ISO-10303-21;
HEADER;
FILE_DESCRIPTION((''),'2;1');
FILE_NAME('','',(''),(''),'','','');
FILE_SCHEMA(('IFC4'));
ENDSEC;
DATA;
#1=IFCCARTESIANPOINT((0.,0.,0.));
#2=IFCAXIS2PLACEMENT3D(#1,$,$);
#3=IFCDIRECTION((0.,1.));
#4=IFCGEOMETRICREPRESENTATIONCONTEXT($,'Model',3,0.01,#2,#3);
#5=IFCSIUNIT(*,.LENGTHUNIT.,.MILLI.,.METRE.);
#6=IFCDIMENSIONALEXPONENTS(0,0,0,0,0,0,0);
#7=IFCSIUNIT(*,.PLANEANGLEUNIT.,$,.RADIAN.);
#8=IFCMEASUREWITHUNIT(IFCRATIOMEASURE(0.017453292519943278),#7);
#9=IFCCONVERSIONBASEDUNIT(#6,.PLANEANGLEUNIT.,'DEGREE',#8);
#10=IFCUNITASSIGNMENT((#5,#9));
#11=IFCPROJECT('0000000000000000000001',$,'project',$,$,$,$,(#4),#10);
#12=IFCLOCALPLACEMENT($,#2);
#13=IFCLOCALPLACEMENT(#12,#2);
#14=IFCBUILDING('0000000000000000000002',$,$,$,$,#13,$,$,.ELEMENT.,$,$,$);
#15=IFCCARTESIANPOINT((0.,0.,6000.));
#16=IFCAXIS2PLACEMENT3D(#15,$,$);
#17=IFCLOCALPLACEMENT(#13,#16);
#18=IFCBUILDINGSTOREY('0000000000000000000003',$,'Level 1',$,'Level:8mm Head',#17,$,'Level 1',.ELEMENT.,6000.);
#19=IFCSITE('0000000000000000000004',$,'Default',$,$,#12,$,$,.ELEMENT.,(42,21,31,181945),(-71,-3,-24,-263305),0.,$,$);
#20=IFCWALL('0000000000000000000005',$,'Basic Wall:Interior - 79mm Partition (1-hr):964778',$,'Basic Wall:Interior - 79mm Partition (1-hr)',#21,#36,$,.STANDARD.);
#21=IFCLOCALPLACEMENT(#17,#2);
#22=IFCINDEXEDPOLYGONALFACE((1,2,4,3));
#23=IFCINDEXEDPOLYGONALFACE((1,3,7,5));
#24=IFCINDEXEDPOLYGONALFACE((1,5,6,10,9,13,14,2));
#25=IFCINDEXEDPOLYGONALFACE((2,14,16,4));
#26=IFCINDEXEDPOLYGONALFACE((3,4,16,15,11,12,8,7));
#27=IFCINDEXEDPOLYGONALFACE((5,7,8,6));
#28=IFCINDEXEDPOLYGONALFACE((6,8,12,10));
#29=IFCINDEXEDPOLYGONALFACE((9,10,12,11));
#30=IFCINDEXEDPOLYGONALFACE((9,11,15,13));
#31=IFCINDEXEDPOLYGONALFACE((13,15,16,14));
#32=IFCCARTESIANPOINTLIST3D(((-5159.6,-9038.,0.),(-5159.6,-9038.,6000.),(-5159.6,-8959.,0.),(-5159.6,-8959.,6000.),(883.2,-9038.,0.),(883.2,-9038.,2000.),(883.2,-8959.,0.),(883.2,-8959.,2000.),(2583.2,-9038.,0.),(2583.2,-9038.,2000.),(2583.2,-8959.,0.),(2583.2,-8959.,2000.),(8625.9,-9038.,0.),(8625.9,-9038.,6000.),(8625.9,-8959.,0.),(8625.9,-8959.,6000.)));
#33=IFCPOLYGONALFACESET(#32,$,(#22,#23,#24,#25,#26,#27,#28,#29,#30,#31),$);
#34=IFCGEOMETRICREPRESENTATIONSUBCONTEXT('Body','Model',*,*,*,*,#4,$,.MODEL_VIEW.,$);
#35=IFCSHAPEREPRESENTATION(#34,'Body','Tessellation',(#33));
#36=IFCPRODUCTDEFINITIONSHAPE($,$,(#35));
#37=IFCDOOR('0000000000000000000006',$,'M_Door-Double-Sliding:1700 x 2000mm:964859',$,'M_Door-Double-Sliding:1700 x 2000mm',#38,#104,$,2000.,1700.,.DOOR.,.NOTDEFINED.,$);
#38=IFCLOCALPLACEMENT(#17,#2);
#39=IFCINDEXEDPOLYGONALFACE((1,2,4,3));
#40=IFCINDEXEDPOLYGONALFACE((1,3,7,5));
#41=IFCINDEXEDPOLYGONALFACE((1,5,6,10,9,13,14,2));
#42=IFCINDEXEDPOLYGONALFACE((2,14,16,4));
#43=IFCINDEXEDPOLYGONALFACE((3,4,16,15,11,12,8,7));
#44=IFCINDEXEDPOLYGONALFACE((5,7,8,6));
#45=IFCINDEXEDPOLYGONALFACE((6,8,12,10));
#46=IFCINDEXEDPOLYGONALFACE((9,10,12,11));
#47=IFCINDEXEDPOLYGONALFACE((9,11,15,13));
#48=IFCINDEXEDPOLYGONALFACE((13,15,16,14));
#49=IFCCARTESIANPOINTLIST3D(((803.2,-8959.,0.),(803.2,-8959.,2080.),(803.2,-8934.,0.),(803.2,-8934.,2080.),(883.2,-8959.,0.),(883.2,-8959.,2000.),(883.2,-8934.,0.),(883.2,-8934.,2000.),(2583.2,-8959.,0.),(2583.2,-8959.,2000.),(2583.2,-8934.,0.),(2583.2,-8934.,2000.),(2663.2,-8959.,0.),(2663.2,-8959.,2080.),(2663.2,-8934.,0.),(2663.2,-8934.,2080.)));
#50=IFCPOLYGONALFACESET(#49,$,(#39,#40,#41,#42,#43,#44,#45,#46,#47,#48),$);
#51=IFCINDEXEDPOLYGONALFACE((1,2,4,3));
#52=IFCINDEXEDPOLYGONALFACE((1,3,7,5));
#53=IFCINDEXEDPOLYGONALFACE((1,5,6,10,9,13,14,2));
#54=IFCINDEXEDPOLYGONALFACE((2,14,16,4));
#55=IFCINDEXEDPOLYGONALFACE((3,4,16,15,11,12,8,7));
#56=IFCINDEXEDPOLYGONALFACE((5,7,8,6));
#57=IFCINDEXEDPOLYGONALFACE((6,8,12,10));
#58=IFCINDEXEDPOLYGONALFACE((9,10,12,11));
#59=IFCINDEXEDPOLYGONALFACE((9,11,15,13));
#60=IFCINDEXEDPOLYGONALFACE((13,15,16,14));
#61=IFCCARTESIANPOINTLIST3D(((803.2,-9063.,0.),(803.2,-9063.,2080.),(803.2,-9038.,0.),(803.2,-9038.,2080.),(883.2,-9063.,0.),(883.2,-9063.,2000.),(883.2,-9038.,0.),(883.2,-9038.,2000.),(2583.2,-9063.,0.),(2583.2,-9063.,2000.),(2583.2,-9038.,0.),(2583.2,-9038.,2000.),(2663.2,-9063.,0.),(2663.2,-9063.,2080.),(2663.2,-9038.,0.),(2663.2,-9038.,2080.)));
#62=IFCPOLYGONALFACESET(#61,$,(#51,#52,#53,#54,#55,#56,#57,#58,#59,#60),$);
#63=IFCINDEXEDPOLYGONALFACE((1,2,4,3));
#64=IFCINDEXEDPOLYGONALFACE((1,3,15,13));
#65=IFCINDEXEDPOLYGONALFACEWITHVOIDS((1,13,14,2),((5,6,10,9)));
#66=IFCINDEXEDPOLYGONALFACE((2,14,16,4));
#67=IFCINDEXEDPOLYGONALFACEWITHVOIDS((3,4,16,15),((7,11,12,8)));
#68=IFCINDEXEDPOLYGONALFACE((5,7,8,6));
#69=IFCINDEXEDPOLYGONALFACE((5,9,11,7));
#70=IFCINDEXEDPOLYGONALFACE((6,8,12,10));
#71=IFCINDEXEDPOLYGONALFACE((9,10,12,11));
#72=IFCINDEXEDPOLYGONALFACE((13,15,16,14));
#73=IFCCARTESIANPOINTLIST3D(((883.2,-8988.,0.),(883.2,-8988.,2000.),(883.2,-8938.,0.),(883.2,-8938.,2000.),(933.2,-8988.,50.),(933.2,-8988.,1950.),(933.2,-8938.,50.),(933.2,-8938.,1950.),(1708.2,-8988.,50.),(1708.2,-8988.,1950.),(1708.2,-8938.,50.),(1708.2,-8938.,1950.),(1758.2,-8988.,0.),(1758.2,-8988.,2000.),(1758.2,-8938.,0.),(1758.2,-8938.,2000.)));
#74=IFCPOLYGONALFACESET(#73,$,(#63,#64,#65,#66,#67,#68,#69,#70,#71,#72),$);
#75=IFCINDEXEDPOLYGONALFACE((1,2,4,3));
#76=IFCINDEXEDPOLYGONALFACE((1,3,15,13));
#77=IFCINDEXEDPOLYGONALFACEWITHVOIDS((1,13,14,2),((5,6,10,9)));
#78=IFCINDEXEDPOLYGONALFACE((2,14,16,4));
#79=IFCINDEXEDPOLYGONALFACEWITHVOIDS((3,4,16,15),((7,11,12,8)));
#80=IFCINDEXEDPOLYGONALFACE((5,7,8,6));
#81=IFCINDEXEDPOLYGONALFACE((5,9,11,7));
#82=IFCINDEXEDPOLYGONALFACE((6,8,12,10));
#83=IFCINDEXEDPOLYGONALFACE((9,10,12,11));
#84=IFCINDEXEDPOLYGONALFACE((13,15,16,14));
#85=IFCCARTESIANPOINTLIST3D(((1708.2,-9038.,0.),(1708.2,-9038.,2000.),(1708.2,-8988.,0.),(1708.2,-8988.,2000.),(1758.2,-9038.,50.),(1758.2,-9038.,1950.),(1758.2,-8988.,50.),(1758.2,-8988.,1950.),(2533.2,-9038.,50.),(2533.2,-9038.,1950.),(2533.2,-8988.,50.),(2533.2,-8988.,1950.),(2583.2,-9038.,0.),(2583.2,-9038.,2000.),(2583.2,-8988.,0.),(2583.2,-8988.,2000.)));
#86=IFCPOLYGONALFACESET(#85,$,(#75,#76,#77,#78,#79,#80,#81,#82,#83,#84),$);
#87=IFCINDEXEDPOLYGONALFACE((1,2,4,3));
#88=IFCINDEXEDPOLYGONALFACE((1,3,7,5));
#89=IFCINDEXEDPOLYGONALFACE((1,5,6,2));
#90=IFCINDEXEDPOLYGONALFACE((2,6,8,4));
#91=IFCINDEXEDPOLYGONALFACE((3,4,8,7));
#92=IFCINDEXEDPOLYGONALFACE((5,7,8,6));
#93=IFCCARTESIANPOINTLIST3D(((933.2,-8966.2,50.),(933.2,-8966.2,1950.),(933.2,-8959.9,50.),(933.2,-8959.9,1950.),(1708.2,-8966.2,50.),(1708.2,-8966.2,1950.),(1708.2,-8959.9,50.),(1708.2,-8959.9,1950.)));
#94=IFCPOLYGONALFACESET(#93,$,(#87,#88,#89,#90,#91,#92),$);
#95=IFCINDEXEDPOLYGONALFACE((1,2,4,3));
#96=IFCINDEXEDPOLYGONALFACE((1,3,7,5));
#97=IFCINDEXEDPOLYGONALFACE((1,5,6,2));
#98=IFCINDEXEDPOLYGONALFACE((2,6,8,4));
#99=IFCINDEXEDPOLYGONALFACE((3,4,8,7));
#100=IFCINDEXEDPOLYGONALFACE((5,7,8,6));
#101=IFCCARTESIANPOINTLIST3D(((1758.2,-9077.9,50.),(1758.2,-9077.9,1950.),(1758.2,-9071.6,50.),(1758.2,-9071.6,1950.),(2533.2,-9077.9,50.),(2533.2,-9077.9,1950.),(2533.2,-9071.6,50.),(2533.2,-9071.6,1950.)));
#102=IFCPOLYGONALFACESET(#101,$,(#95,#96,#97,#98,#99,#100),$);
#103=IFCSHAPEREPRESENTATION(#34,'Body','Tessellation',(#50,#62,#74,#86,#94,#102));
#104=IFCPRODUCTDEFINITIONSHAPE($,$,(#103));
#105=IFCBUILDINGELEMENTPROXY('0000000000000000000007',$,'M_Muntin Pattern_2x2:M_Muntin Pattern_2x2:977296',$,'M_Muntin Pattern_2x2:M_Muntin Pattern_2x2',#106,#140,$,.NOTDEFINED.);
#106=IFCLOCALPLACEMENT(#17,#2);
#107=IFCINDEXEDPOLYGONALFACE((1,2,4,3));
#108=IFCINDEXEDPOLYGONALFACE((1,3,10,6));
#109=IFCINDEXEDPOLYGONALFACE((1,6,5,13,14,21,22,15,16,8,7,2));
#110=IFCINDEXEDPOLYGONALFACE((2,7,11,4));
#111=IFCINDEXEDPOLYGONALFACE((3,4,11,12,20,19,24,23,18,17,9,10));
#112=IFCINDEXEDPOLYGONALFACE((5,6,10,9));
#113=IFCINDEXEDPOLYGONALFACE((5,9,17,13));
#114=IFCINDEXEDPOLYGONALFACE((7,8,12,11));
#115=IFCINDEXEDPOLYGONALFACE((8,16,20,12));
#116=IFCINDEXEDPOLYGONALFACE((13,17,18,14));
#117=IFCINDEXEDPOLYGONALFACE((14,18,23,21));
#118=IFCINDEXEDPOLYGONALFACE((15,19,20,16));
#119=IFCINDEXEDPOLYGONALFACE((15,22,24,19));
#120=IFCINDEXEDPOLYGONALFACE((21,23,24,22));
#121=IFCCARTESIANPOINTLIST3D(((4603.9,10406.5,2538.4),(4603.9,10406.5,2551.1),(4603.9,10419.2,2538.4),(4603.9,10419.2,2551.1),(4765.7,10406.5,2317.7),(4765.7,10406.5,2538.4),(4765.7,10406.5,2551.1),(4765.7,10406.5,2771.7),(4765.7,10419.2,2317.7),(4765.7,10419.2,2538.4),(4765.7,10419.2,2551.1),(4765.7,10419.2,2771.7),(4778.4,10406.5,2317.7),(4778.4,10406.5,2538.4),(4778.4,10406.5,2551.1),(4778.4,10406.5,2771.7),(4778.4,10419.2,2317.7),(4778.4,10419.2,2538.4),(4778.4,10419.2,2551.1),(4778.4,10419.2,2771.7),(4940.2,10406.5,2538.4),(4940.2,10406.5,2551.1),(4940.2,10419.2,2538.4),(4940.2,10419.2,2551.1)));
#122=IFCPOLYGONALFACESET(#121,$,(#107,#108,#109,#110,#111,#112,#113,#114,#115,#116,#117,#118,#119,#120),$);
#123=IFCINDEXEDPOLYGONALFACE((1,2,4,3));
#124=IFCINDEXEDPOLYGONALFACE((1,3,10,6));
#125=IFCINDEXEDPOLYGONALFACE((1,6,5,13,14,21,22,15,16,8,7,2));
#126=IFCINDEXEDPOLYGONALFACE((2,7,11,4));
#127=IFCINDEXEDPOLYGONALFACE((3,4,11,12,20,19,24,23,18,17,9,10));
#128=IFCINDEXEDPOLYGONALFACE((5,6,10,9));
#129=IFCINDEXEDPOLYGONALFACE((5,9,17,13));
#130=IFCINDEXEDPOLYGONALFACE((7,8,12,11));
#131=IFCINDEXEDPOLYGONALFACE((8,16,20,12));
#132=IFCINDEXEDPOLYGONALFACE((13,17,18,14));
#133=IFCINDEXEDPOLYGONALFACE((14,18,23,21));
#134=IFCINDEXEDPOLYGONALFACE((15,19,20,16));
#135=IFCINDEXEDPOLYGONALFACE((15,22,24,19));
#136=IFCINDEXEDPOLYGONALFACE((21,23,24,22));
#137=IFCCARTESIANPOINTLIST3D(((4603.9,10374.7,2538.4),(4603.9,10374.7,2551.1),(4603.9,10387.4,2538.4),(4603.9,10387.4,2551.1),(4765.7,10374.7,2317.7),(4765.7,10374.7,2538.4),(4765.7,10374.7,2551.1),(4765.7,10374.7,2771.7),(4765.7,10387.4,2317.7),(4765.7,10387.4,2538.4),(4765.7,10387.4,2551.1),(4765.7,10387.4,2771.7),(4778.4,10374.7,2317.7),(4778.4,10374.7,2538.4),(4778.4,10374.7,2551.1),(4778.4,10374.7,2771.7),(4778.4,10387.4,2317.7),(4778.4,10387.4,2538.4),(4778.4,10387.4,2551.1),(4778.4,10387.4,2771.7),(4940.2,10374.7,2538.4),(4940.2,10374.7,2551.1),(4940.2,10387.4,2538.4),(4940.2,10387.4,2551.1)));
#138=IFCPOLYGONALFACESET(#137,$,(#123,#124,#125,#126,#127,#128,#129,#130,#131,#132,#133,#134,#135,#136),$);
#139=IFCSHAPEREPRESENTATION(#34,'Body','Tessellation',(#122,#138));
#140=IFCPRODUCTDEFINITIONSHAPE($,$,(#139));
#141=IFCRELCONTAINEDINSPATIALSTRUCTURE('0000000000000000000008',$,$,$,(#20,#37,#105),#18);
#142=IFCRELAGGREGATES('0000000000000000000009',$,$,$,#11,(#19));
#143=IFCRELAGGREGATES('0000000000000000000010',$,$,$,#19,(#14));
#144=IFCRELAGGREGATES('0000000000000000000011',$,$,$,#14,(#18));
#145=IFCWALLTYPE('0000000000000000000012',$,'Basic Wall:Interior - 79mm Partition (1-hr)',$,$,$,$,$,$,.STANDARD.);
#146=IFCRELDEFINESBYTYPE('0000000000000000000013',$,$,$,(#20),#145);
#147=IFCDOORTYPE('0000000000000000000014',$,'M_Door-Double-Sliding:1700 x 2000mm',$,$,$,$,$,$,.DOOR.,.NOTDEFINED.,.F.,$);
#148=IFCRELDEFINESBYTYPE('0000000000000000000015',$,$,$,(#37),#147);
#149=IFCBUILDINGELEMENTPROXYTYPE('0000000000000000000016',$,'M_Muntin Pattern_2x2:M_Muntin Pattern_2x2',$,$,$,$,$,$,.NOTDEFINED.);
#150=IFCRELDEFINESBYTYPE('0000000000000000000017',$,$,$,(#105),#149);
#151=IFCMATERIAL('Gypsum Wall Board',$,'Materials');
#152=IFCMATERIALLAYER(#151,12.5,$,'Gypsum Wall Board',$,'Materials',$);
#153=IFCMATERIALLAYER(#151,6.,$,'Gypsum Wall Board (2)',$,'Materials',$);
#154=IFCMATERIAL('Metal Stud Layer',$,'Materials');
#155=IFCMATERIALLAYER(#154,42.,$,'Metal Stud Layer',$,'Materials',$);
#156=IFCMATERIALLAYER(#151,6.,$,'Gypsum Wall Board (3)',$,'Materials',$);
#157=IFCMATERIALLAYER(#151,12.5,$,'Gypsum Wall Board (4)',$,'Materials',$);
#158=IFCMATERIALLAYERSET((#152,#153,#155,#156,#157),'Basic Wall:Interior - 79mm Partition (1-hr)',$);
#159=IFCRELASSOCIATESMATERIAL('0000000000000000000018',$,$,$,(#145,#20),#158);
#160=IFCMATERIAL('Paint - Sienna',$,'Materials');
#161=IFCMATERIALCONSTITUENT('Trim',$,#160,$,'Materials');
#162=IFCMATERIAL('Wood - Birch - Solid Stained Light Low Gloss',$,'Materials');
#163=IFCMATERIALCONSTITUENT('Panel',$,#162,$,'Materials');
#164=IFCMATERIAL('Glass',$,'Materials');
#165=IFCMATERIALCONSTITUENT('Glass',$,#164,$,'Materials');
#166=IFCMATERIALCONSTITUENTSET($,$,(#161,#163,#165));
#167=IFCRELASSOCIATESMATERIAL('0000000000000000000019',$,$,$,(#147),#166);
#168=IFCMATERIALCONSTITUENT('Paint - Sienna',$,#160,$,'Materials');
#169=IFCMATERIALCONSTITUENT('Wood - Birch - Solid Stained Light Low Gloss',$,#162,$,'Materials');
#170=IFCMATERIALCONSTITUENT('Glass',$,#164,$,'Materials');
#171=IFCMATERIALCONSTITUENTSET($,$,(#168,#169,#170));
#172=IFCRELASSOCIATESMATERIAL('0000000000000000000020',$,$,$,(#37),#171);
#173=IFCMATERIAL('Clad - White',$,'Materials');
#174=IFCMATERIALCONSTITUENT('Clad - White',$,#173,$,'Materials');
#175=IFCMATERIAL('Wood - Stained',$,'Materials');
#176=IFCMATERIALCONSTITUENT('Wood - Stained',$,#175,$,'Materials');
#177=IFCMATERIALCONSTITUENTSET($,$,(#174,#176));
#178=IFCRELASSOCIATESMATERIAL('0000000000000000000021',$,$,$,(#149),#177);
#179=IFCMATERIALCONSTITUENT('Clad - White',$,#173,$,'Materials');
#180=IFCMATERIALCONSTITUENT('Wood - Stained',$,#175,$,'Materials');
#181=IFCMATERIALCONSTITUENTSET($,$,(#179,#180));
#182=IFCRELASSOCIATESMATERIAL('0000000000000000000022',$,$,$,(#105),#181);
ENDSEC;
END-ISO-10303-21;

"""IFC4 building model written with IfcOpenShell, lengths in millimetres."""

from ifc_helpers import new_model, entity, si_unit, converted_unit, direction, frame, frame_2d, origin, origin_2d_with_axis, place, context, subcontext, project, spatial, polyline, rectangle, outline, extrude, source, transform, mapped, material, layer, layer_set, layer_usage, constituent, constituent_set, type_object, type_shapes, element, fill, save


model = new_model("IFC4")

# Units and contexts
model_context = context("Model", 3, precision=0.01, world=origin(), true_north=direction((0.0, 1.0)))
body_context = subcontext(model_context, "Body", "Model", "MODEL_VIEW")
ifc_project = project(units=[si_unit("LENGTHUNIT", "METRE", prefix="MILLI"), converted_unit("PLANEANGLEUNIT", "DEGREE", entity("IfcRatioMeasure", 0.017453292519943278), si_unit("PLANEANGLEUNIT", "RADIAN"), dimensions=[0, 0, 0, 0, 0, 0, 0])], contexts=[model_context])

# Site, building, storey
site_placement = place(None, origin())
site = spatial("IfcSite", under=ifc_project, at=site_placement, Name="Default", CompositionType="ELEMENT", RefLatitude=(42, 21, 31, 181945), RefLongitude=(-71, -3, -24, -263305), RefElevation=0.0)
building_placement = place(site_placement, origin())
building = spatial("IfcBuilding", under=site, at=building_placement, CompositionType="ELEMENT")
storey_placement = place(building_placement, frame((0.0, 0.0, 6000.0)))
storey = spatial("IfcBuildingStorey", under=building, at=storey_placement, Name="Level 1", ObjectType="Level:8mm Head", LongName="Level 1", CompositionType="ELEMENT", Elevation=6000.0)

# Shared definitions
ifc_material_1 = material(Name="Gypsum Wall Board", Category="Materials")
ifc_layer_1 = layer(ifc_material_1, 12.5, Name="Gypsum Wall Board", Category="Materials")
ifc_layer_2 = layer(ifc_material_1, 6.0, Name="Gypsum Wall Board (2)", Category="Materials")
ifc_material_2 = material(Name="Metal Stud Layer", Category="Materials")
ifc_layer_3 = layer(ifc_material_2, 42.0, Name="Metal Stud Layer", Category="Materials")
ifc_layer_4 = layer(ifc_material_1, 6.0, Name="Gypsum Wall Board (3)", Category="Materials")
ifc_layer_5 = layer(ifc_material_1, 12.5, Name="Gypsum Wall Board (4)", Category="Materials")
ifc_layer_set_1 = layer_set([ifc_layer_1, ifc_layer_2, ifc_layer_3, ifc_layer_4, ifc_layer_5], Name="Basic Wall:Interior - 79mm Partition (1-hr)")
ifc_layer_usage_1 = layer_usage(ifc_layer_set_1, "AXIS2", "NEGATIVE", 39.5)
wall_type = type_object("IfcWallType", Name="Basic Wall:Interior - 79mm Partition (1-hr)", PredefinedType="STANDARD", material=ifc_layer_set_1)

# Wall, opening, door
ifc_material_3 = material(Name="Paint - Sienna", Category="Materials")
ifc_material_4 = material(Name="Wood - Birch - Solid Stained Light Low Gloss", Category="Materials")
ifc_material_5 = material(Name="Glass", Category="Materials")
ifc_constituent_1 = constituent(ifc_material_3, Name="Trim", Category="Materials")
ifc_constituent_2 = constituent(ifc_material_4, Name="Panel", Category="Materials")
ifc_constituent_3 = constituent(ifc_material_5, Name="Glass", Category="Materials")
ifc_constituent_set_1 = constituent_set(constituents=[ifc_constituent_1, ifc_constituent_2, ifc_constituent_3])
door_type = type_object("IfcDoorType", Name="M_Door-Double-Sliding:1700 x 2000mm", OperationType="NOTDEFINED", ParameterTakesPrecedence=False, PredefinedType="DOOR", material=ifc_constituent_set_1)
shared_shape_1 = source(origin(), body_context, "Body", "SweptSolid", [
    extrude(outline(polyline([(-1020.0, -930.0), (1060.0, -930.0), (1060.0, 930.0), (-1020.0, 930.0), (-1020.0, 850.0), (980.0, 850.0), (980.0, -850.0), (-1020.0, -850.0), (-1020.0, -930.0)])), frame((850.0, -25.0, 1020.0), z_axis=(0.0, 1.0, 0.0), x_axis=(0.0, 0.0, 1.0)), (0.0, 0.0, 1.0), 25.0),
    extrude(outline(polyline([(-930.0, -1020.0), (-850.0, -1020.0), (-850.0, 980.0), (850.0, 980.0), (850.0, -1020.0), (930.0, -1020.0), (930.0, 1060.0), (-930.0, 1060.0), (-930.0, -1020.0)])), frame((850.0, 79.0, 1020.0), z_axis=(0.0, 1.0, 0.0), x_axis=(-1.0, 0.0, 0.0)), (0.0, 0.0, 1.0), 25.0),
    extrude(outline(polyline([(-437.5, -1000.0), (437.5, -1000.0), (437.5, 1000.0), (-437.5, 1000.0), (-437.5, -1000.0)]), holes=[polyline([(-387.5, -950.0), (-387.5, 950.0), (387.5, 950.0), (387.5, -950.0), (-387.5, -950.0)])]), frame((1262.5, -21.0, 1000.0), z_axis=(0.0, 1.0, 0.0), x_axis=(1.0, 0.0, 0.0)), (0.0, 0.0, 1.0), 50.0),
    extrude(outline(polyline([(-1000.0, -437.5), (1000.0, -437.5), (1000.0, 437.5), (-1000.0, 437.5), (-1000.0, -437.5)]), holes=[polyline([(-950.0, -387.5), (-950.0, 387.5), (950.0, 387.5), (950.0, -387.5), (-950.0, -387.5)])]), frame((437.5, 29.0, 1000.0), z_axis=(0.0, 1.0, 0.0), x_axis=(0.0, 0.0, -1.0)), (0.0, 0.0, 1.0), 50.0),
    extrude(rectangle(XDim=6.3, YDim=775.0, at=frame_2d((0.0, 0.0), x_axis=(1.0, 0.0))), frame((1262.5, 4.0, 50.0), z_axis=(0.0, 0.0, 1.0), x_axis=(0.0, -1.0, 0.0)), (0.0, 0.0, 1.0), 1900.0),
    extrude(rectangle(XDim=6.4, YDim=775.0, at=origin_2d_with_axis()), frame((437.5, 115.7, 50.0), z_axis=(0.0, 0.0, 1.0), x_axis=(0.0, 1.0, 0.0)), (0.0, 0.0, 1.0), 1900.0),
])
type_shapes(door_type, [shared_shape_1])
wall_1_placement = place(storey_placement, frame((-5159.6, -8998.5, 0.0)))
wall_1 = element("IfcWall", 1, at=wall_1_placement, inside=storey, type_object=wall_type, material=ifc_layer_usage_1, Name="Basic Wall:Interior - 79mm Partition (1-hr):964778", ObjectType="Basic Wall:Interior - 79mm Partition (1-hr)", PredefinedType="STANDARD", context=body_context, shape_type="SweptSolid", body=[
    extrude(rectangle(XDim=13785.5, YDim=79.0, at=frame_2d((6892.8, 0.0), x_axis=(1.0, 0.0))), origin(), (0.0, 0.0, 1.0), 6000.0),
])
opening_1_placement = place(wall_1_placement, frame((7742.8, 39.5, 0.0)))
opening_1 = element("IfcOpeningElement", 2, at=opening_1_placement, cuts=wall_1, PredefinedType="OPENING", context=body_context, shape_type="SweptSolid", body=[
    extrude(rectangle(XDim=2000.0, YDim=1700.0, at=frame_2d((1000.0, 850.0), x_axis=(-1.0, 0.0))), frame((0.0, 0.0, 0.0), z_axis=(0.0, -1.0, 0.0), x_axis=(0.0, 0.0, 1.0)), (0.0, 0.0, 1.0), 79.0),
])
ifc_constituent_4 = constituent(ifc_material_3, Name="Paint - Sienna", Category="Materials")
ifc_constituent_5 = constituent(ifc_material_4, Name="Wood - Birch - Solid Stained Light Low Gloss", Category="Materials")
ifc_constituent_6 = constituent(ifc_material_5, Name="Glass", Category="Materials")
ifc_constituent_set_2 = constituent_set(constituents=[ifc_constituent_4, ifc_constituent_5, ifc_constituent_6])
door_1_placement = place(opening_1_placement, frame((0.0, 0.0, 0.0), z_axis=(0.0, 0.0, 1.0), x_axis=(-1.0, 0.0, 0.0)))
door_1 = element("IfcDoor", 3, at=door_1_placement, inside=storey, type_object=door_type, material=ifc_constituent_set_2, Name="M_Door-Double-Sliding:1700 x 2000mm:964859", ObjectType="M_Door-Double-Sliding:1700 x 2000mm", OperationType="NOTDEFINED", OverallHeight=2000.0, OverallWidth=1700.0, PredefinedType="DOOR", context=body_context, shape_type="MappedRepresentation", body=[
    mapped(shared_shape_1, transform((0.0, 0.0, 0.0), scale=1.0)),
])
fill(opening_1, door_1)

# Building element proxy
ifc_material_6 = material(Name="Clad - White", Category="Materials")
ifc_constituent_7 = constituent(ifc_material_6, Name="Clad - White", Category="Materials")
ifc_material_7 = material(Name="Wood - Stained", Category="Materials")
ifc_constituent_8 = constituent(ifc_material_7, Name="Wood - Stained", Category="Materials")
ifc_constituent_set_3 = constituent_set(constituents=[ifc_constituent_7, ifc_constituent_8])
ifc_constituent_9 = constituent(ifc_material_6, Name="Clad - White", Category="Materials")
ifc_constituent_10 = constituent(ifc_material_7, Name="Wood - Stained", Category="Materials")
ifc_constituent_set_4 = constituent_set(constituents=[ifc_constituent_9, ifc_constituent_10])
building_element_proxy_type_1 = type_object("IfcBuildingElementProxyType", Name="M_Muntin Pattern_2x2:M_Muntin Pattern_2x2", PredefinedType="NOTDEFINED", material=ifc_constituent_set_4)
shared_shape_2 = source(origin(), body_context, "Body", "SweptSolid", [
    extrude(outline(polyline([(6.4, -6.4), (227.0, -6.4), (227.0, 6.3), (6.4, 6.3), (6.4, 168.2), (-6.3, 168.2), (-6.3, 6.3), (-227.0, 6.3), (-227.0, -6.4), (-6.3, -6.4), (-6.3, -168.1), (6.4, -168.1), (6.4, -6.4)])), frame((0.0, 9.5, 227.0), z_axis=(0.0, 1.0, 0.0), x_axis=(0.0, 0.0, 1.0)), (0.0, 0.0, 1.0), 12.7),
    extrude(outline(polyline([(6.4, -6.4), (227.0, -6.4), (227.0, 6.3), (6.4, 6.3), (6.4, 168.2), (-6.3, 168.2), (-6.3, 6.3), (-227.0, 6.3), (-227.0, -6.4), (-6.3, -6.4), (-6.3, -168.1), (6.4, -168.1), (6.4, -6.4)])), frame((0.0, -22.2, 227.0), z_axis=(0.0, 1.0, 0.0), x_axis=(0.0, 0.0, 1.0)), (0.0, 0.0, 1.0), 12.7),
])
type_shapes(building_element_proxy_type_1, [shared_shape_2])
proxy_1_placement = place(storey_placement, frame((4772.1, 10396.9, 2317.7)))
element("IfcBuildingElementProxy", 4, at=proxy_1_placement, inside=storey, type_object=building_element_proxy_type_1, material=ifc_constituent_set_3, Name="M_Muntin Pattern_2x2:M_Muntin Pattern_2x2:977296", ObjectType="M_Muntin Pattern_2x2:M_Muntin Pattern_2x2", PredefinedType="NOTDEFINED", context=body_context, shape_type="MappedRepresentation", body=[
    mapped(shared_shape_2, transform((0.0, 0.0, 0.0), scale=1.0)),
])

save(model, "model.ifc")
